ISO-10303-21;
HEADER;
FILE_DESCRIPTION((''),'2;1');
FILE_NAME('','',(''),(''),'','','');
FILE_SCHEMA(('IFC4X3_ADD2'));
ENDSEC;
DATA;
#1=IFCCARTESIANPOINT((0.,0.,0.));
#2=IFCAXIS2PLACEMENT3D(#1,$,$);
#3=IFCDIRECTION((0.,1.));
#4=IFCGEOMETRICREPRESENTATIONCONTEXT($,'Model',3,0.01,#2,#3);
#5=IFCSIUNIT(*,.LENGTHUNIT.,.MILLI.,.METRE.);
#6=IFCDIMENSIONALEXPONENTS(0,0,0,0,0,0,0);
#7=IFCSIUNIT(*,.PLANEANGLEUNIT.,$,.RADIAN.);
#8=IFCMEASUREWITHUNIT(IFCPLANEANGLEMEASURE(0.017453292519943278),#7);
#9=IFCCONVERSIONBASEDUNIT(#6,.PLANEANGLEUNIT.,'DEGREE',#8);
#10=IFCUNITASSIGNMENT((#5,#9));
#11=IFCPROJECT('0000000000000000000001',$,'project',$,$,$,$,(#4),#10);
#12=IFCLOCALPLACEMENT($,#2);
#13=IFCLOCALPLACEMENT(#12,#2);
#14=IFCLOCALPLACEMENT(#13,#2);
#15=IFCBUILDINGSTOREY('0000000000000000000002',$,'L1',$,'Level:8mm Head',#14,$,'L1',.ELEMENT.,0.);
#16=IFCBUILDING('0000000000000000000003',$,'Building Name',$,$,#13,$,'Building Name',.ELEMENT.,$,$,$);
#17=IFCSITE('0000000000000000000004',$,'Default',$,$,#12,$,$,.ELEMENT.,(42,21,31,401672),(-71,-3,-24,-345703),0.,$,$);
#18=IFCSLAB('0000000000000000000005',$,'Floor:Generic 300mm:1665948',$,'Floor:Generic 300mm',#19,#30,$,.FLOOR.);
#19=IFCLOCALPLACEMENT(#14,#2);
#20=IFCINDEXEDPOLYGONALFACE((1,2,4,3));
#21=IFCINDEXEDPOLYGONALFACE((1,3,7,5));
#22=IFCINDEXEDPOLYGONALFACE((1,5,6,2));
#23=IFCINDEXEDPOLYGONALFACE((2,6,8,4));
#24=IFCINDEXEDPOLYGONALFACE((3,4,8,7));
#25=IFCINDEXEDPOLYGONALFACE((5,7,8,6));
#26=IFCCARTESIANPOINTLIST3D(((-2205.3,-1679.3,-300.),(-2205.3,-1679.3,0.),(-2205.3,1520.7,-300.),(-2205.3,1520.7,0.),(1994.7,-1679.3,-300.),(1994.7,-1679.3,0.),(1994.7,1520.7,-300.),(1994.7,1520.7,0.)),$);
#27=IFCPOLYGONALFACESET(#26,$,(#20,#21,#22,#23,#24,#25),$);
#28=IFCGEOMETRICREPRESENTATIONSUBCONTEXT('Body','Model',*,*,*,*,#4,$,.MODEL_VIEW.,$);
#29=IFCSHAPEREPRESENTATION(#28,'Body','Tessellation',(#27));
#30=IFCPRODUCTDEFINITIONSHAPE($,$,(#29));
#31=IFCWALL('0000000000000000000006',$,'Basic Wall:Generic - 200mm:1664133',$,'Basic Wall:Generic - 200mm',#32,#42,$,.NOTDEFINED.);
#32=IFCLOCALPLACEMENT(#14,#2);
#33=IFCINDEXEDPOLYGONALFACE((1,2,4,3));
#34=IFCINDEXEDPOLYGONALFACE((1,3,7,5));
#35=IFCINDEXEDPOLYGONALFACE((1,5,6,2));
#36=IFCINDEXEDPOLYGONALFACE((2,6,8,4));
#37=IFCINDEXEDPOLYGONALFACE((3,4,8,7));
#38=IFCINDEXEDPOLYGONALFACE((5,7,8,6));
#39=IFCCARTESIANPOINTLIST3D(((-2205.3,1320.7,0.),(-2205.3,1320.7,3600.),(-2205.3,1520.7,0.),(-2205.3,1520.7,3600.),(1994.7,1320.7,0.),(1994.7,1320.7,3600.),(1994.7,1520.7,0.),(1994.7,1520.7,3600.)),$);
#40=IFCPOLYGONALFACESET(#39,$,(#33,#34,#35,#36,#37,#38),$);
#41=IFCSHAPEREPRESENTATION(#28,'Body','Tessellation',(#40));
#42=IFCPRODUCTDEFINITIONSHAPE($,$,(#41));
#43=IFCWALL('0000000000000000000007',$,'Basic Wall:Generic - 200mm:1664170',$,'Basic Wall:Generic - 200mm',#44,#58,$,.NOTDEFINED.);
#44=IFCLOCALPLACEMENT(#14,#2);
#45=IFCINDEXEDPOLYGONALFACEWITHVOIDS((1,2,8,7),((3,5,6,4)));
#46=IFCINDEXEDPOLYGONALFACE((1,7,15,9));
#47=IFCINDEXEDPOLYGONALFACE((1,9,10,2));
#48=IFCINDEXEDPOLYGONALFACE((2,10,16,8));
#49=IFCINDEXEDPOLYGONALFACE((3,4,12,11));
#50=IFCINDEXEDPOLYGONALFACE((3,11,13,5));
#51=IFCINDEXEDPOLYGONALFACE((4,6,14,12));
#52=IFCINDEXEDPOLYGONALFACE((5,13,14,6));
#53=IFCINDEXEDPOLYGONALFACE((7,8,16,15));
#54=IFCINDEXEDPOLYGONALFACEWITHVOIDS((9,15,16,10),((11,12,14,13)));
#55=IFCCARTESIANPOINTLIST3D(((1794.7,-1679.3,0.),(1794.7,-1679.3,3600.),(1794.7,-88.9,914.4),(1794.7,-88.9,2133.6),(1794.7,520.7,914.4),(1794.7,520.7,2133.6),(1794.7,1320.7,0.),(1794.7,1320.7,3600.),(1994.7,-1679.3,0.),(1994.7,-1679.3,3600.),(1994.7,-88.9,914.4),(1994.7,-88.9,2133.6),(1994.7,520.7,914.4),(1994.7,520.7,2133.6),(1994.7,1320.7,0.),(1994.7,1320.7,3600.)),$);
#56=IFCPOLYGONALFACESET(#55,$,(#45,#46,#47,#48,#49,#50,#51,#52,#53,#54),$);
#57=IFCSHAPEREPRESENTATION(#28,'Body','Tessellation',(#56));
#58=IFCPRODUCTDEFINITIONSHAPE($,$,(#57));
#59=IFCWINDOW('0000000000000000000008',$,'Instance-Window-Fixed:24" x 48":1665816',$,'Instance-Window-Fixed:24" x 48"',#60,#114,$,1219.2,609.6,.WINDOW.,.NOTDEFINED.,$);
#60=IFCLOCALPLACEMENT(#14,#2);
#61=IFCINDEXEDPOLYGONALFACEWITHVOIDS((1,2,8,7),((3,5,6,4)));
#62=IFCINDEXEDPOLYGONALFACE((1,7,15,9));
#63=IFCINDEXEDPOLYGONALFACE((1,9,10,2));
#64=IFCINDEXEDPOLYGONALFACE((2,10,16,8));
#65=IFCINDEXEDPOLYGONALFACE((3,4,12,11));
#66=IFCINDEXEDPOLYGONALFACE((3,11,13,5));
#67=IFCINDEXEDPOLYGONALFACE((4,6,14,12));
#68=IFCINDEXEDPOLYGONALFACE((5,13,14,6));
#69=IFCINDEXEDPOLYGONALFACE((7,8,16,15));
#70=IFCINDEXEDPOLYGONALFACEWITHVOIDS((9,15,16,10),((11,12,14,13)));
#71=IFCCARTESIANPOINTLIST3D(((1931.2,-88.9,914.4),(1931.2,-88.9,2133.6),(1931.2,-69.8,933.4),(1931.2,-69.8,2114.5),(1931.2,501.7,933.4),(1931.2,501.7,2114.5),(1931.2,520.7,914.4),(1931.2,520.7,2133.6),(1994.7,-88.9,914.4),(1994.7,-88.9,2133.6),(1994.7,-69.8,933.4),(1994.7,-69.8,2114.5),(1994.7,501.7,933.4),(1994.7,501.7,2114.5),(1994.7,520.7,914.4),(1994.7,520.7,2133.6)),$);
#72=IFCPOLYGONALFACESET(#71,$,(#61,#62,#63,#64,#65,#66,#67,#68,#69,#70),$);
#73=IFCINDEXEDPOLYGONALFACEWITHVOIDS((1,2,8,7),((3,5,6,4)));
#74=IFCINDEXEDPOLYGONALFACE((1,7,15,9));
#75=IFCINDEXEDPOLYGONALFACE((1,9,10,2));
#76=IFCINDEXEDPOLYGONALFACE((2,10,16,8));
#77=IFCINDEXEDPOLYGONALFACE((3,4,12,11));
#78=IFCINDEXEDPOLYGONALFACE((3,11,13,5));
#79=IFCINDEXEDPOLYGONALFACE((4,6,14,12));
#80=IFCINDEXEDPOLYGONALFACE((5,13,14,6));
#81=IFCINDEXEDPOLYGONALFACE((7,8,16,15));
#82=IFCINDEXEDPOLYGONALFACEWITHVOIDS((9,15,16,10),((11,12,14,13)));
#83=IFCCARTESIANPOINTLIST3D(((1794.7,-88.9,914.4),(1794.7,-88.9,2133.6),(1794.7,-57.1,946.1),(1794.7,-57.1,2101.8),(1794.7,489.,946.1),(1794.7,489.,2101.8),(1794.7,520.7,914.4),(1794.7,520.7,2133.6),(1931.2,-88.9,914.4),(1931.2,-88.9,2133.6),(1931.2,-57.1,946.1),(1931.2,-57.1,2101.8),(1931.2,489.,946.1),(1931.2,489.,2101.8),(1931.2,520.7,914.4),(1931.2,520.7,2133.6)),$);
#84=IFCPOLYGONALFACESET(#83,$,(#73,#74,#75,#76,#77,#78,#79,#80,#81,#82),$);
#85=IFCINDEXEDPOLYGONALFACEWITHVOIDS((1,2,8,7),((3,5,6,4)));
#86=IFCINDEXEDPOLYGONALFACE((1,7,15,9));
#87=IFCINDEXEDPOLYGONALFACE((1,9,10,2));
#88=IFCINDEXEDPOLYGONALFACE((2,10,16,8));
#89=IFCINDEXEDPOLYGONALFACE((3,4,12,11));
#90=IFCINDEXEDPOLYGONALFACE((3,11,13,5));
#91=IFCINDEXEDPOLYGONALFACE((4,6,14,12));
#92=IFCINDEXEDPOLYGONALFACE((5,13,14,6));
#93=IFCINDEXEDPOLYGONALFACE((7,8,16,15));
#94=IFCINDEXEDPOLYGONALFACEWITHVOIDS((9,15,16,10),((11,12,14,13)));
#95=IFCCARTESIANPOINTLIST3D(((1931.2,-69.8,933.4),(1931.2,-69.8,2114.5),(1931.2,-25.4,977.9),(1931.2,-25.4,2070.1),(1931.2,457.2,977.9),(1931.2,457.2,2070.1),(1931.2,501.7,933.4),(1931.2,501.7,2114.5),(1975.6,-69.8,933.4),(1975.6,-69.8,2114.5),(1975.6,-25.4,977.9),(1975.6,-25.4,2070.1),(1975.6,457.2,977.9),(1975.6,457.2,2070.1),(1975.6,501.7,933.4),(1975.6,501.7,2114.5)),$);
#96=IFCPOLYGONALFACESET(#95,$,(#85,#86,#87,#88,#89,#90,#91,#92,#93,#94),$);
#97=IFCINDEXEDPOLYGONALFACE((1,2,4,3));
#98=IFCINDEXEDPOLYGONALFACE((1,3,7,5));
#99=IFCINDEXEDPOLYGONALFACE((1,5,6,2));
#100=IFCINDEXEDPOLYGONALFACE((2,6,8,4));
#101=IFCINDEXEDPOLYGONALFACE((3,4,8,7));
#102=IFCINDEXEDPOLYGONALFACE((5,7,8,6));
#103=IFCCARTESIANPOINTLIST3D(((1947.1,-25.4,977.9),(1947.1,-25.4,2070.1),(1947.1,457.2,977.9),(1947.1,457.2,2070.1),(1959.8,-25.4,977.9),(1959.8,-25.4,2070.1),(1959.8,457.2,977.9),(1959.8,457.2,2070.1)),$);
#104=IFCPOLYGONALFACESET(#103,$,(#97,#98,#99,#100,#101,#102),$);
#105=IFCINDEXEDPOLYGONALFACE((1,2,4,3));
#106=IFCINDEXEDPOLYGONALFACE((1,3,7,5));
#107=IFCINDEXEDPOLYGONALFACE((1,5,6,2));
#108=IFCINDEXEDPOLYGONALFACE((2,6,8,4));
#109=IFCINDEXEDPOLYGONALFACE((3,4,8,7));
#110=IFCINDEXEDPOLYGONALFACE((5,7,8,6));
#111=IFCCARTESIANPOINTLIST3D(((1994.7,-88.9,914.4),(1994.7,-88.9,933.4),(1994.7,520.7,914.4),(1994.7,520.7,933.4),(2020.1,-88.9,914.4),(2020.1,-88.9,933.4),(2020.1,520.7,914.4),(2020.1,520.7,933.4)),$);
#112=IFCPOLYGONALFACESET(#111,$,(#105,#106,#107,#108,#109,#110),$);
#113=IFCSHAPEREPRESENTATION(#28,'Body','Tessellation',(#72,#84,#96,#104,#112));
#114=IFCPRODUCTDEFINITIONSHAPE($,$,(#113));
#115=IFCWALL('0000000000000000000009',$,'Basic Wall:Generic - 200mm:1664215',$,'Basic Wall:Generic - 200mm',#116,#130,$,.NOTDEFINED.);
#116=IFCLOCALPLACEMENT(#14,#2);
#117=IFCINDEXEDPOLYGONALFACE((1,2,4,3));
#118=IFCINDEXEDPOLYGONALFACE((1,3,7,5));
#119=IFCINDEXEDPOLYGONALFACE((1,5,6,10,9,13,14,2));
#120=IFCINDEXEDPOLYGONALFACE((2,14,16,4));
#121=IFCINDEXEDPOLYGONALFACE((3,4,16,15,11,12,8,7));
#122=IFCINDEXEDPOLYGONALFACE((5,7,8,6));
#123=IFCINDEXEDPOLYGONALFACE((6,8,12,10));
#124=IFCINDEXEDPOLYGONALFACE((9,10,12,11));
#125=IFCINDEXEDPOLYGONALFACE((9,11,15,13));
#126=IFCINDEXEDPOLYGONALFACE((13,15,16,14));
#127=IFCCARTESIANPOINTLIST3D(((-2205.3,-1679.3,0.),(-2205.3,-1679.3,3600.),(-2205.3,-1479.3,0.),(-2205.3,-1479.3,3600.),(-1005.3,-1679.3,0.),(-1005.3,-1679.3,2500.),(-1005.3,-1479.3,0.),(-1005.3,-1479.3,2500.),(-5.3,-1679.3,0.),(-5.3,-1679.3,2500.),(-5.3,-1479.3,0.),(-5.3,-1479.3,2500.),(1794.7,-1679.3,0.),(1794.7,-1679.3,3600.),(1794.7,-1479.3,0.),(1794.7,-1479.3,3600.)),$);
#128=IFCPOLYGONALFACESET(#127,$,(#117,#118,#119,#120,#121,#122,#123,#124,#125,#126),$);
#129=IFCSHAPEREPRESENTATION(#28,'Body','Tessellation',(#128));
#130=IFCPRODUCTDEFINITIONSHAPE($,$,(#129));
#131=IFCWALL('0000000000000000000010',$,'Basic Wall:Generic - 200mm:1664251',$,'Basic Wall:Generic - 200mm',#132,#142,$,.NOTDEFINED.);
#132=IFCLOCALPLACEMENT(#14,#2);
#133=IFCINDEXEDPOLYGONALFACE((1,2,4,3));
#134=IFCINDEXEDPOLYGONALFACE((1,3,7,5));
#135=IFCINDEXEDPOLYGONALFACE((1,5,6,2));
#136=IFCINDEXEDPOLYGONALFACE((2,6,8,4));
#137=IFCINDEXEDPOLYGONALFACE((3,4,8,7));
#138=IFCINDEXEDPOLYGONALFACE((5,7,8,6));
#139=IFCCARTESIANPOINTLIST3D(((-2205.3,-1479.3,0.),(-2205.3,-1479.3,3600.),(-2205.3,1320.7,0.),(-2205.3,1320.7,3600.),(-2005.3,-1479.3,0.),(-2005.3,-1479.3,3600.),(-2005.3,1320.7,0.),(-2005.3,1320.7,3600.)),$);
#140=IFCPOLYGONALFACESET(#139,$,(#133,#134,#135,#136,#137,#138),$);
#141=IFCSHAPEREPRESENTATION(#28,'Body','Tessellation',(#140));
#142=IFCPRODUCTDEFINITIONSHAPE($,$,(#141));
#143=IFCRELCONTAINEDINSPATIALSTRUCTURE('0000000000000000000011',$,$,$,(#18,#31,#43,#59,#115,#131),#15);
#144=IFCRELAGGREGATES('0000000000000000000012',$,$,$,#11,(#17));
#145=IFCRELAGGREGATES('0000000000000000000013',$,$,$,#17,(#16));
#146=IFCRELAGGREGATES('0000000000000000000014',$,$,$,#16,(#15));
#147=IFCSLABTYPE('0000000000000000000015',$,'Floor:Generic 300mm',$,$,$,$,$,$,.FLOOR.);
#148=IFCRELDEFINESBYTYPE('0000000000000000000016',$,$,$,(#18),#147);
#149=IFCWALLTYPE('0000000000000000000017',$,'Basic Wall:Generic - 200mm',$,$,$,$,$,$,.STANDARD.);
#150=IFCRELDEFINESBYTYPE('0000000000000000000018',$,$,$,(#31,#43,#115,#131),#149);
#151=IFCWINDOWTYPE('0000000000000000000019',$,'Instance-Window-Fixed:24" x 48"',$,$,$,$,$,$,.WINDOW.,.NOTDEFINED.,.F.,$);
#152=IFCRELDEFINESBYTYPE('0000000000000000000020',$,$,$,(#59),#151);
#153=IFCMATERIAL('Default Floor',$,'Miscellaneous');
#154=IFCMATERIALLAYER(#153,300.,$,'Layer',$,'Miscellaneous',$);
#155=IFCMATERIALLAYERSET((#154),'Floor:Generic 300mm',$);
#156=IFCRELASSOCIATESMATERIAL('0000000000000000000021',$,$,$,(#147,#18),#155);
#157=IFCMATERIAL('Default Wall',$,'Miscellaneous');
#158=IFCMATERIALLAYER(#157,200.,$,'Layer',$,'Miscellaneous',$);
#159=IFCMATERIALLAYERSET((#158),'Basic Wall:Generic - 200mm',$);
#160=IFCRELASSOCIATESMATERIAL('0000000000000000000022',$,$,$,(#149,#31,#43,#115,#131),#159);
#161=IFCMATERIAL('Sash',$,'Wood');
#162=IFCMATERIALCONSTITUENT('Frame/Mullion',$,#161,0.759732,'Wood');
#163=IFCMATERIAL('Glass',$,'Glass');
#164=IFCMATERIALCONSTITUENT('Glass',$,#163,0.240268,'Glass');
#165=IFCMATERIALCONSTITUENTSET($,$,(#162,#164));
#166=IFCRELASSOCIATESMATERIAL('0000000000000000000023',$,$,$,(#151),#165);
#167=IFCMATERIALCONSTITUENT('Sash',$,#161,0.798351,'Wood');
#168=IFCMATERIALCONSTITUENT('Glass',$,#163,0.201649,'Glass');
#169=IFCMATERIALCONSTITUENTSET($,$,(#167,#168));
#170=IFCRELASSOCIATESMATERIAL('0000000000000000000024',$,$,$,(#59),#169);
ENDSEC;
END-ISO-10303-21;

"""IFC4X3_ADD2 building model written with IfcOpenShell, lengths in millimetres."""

from ifc_helpers import new_model, entity, si_unit, converted_unit, direction, frame, frame_2d, origin, origin_2d_with_axis, place, context, subcontext, project, spatial, polyline, rectangle, outline, extrude, source, transform, mapped, material, layer, layer_set, layer_usage, constituent, constituent_set, type_object, type_shapes, element, fill, save


model = new_model("IFC4X3_ADD2")

# Units and contexts
model_context = context("Model", 3, precision=0.01, world=origin(), true_north=direction((0.0, 1.0)))
body_context = subcontext(model_context, "Body", "Model", "MODEL_VIEW")
ifc_project = project(units=[si_unit("LENGTHUNIT", "METRE", prefix="MILLI"), converted_unit("PLANEANGLEUNIT", "DEGREE", entity("IfcPlaneAngleMeasure", 0.017453292519943278), si_unit("PLANEANGLEUNIT", "RADIAN"), dimensions=[0, 0, 0, 0, 0, 0, 0])], contexts=[model_context])

# Site, building, storey
site_placement = place(None, origin())
site = spatial("IfcSite", under=ifc_project, at=site_placement, Name="Default", CompositionType="ELEMENT", RefLatitude=(42, 21, 31, 401672), RefLongitude=(-71, -3, -24, -345703), RefElevation=0.0)
building_placement = place(site_placement, origin())
building = spatial("IfcBuilding", under=site, at=building_placement, Name="Building Name", LongName="Building Name", CompositionType="ELEMENT")
storey_placement = place(building_placement, origin())
storey = spatial("IfcBuildingStorey", under=building, at=storey_placement, Name="L1", ObjectType="Level:8mm Head", LongName="L1", CompositionType="ELEMENT", Elevation=0.0)

# Slab
ifc_material_1 = material(Name="Default Floor", Category="Miscellaneous")
ifc_layer_1 = layer(ifc_material_1, 300.0, Name="Layer", Category="Miscellaneous")
ifc_layer_set_1 = layer_set([ifc_layer_1], Name="Floor:Generic 300mm")
ifc_layer_usage = layer_usage(ifc_layer_set_1, "AXIS3", "POSITIVE", 0.0)
slab_type = type_object("IfcSlabType", Name="Floor:Generic 300mm", PredefinedType="FLOOR", material=ifc_layer_set_1)
slab_placement = place(storey_placement, origin())
element("IfcSlab", 1, at=slab_placement, inside=storey, type_object=slab_type, material=ifc_layer_usage, Name="Floor:Generic 300mm:1665948", ObjectType="Floor:Generic 300mm", PredefinedType="FLOOR", context=body_context, shape_type="SweptSolid", body=[
    extrude(rectangle(XDim=3200.0, YDim=4200.0, at=origin_2d_with_axis()), frame((-105.3, -79.3, 0.0), z_axis=(0.0, 0.0, -1.0), x_axis=(0.0, 1.0, 0.0)), (0.0, 0.0, 1.0), 300.0),
])

# Wall
ifc_material_2 = material(Name="Default Wall", Category="Miscellaneous")
ifc_layer_2 = layer(ifc_material_2, 200.0, Name="Layer", Category="Miscellaneous")
ifc_layer_set_2 = layer_set([ifc_layer_2], Name="Basic Wall:Generic - 200mm")
wall_type = type_object("IfcWallType", Name="Basic Wall:Generic - 200mm", PredefinedType="STANDARD", material=ifc_layer_set_2)
wall_1_placement = place(storey_placement, frame((-2205.3, 1420.7, 0.0)))
element("IfcWall", 2, at=wall_1_placement, inside=storey, type_object=wall_type, material=ifc_layer_set_2, Name="Basic Wall:Generic - 200mm:1664133", ObjectType="Basic Wall:Generic - 200mm", PredefinedType="NOTDEFINED", context=body_context, shape_type="SweptSolid", body=[
    extrude(rectangle(XDim=4200.0, YDim=200.0, at=frame_2d((2100.0, 0.0), x_axis=(-1.0, 0.0))), origin(), (0.0, 0.0, 1.0), 3600.0),
])

# Wall, opening, window
wall_2_placement = place(storey_placement, frame((1894.7, 1320.7, 0.0), z_axis=(0.0, 0.0, 1.0), x_axis=(0.0, -1.0, 0.0)))
wall_2 = element("IfcWall", 3, at=wall_2_placement, inside=storey, type_object=wall_type, material=ifc_layer_set_2, Name="Basic Wall:Generic - 200mm:1664170", ObjectType="Basic Wall:Generic - 200mm", PredefinedType="NOTDEFINED", context=body_context, shape_type="SweptSolid", body=[
    extrude(rectangle(XDim=3000.0, YDim=200.0, at=frame_2d((1500.0, 0.0), x_axis=(-1.0, 0.0))), origin(), (0.0, 0.0, 1.0), 3600.0),
])
opening_1_placement = place(wall_2_placement, frame((800.0, -100.0, 914.4)))
opening_1 = element("IfcOpeningElement", 4, at=opening_1_placement, cuts=wall_2, PredefinedType="OPENING", context=body_context, shape_type="SweptSolid", body=[
    extrude(rectangle(XDim=1219.2, YDim=609.6, at=frame_2d((609.6, 304.8), x_axis=(-1.0, 0.0))), frame((0.0, 0.0, 0.0), z_axis=(0.0, 1.0, 0.0), x_axis=(0.0, 0.0, 1.0)), (0.0, 0.0, 1.0), 200.0),
])
ifc_material_3 = material(Name="Sash", Category="Wood")
ifc_constituent_1 = constituent(ifc_material_3, Name="Sash", Category="Wood", fraction=0.798351)
ifc_material_4 = material(Name="Glass", Category="Glass")
ifc_constituent_2 = constituent(ifc_material_4, Name="Glass", Category="Glass", fraction=0.201649)
ifc_constituent_set_1 = constituent_set(constituents=[ifc_constituent_1, ifc_constituent_2])
ifc_constituent_3 = constituent(ifc_material_3, Name="Frame/Mullion", Category="Wood", fraction=0.759732)
ifc_constituent_4 = constituent(ifc_material_4, Name="Glass", Category="Glass", fraction=0.240268)
ifc_constituent_set_2 = constituent_set(constituents=[ifc_constituent_3, ifc_constituent_4])
window_type = type_object("IfcWindowType", Name="Instance-Window-Fixed:24\" x 48\"", ParameterTakesPrecedence=False, PartitioningType="NOTDEFINED", PredefinedType="WINDOW", material=ifc_constituent_set_2)
shared_shape = source(origin(), body_context, "Body", "SweptSolid", [
    extrude(outline(polyline([(-609.6, -304.8), (609.6, -304.8), (609.6, 304.8), (-609.6, 304.8), (-609.6, -304.8)]), holes=[polyline([(-590.5, -285.7), (-590.5, 285.8), (590.6, 285.8), (590.6, -285.7), (-590.5, -285.7)])]), frame((304.8, 136.5, 609.6), z_axis=(0.0, 1.0, 0.0), x_axis=(0.0, 0.0, -1.0)), (0.0, 0.0, 1.0), 63.5),
    extrude(outline(polyline([(-304.8, -609.6), (304.8, -609.6), (304.8, 609.6), (-304.8, 609.6), (-304.8, -609.6)]), holes=[polyline([(-273.1, -577.8), (-273.1, 577.9), (273.0, 577.9), (273.0, -577.8), (-273.1, -577.8)])]), frame((304.8, 0.0, 609.6), z_axis=(0.0, 1.0, 0.0), x_axis=(1.0, 0.0, 0.0)), (0.0, 0.0, 1.0), 136.5),
    extrude(outline(polyline([(-285.7, -590.6), (285.7, -590.6), (285.7, 590.6), (-285.7, 590.6), (-285.7, -590.6)]), holes=[polyline([(-241.3, -546.1), (-241.3, 546.1), (241.3, 546.1), (241.3, -546.1), (-241.3, -546.1)])]), frame((304.8, 136.5, 609.6), z_axis=(0.0, 1.0, 0.0), x_axis=(1.0, 0.0, 0.0)), (0.0, 0.0, 1.0), 44.4),
    extrude(rectangle(XDim=12.7, YDim=482.6, at=frame_2d((0.0, 0.0), x_axis=(1.0, 0.0))), frame((304.8, 158.7, 63.5), z_axis=(0.0, 0.0, 1.0), x_axis=(0.0, 1.0, 0.0)), (0.0, 0.0, 1.0), 1092.2),
    extrude(rectangle(XDim=25.4, YDim=609.6, at=frame_2d((0.0, 0.0), x_axis=(1.0, 0.0))), frame((304.8, 212.7, 0.0), z_axis=(0.0, 0.0, 1.0), x_axis=(0.0, -1.0, 0.0)), (0.0, 0.0, 1.0), 19.0),
])
type_shapes(window_type, [shared_shape])
window_placement = place(opening_1_placement, origin())
window = element("IfcWindow", 5, at=window_placement, inside=storey, type_object=window_type, material=ifc_constituent_set_1, Name="Instance-Window-Fixed:24\" x 48\":1665816", ObjectType="Instance-Window-Fixed:24\" x 48\"", OverallHeight=1219.2, OverallWidth=609.6, PartitioningType="NOTDEFINED", PredefinedType="WINDOW", context=body_context, shape_type="MappedRepresentation", body=[
    mapped(shared_shape, transform((0.0, 0.0, 0.0), scale=1.0)),
])
fill(opening_1, window)

# Wall, opening
wall_3_placement = place(storey_placement, frame((1794.7, -1579.3, 0.0), z_axis=(0.0, 0.0, 1.0), x_axis=(-1.0, 0.0, 0.0)))
wall_3 = element("IfcWall", 6, at=wall_3_placement, inside=storey, type_object=wall_type, material=ifc_layer_set_2, Name="Basic Wall:Generic - 200mm:1664215", ObjectType="Basic Wall:Generic - 200mm", PredefinedType="NOTDEFINED", context=body_context, shape_type="SweptSolid", body=[
    extrude(rectangle(XDim=4000.0, YDim=200.0, at=frame_2d((2000.0, 0.0), x_axis=(1.0, 0.0))), origin(), (0.0, 0.0, 1.0), 3600.0),
])
opening_2_placement = place(wall_3_placement, frame((1800.0, -100.0, 0.0)))
element("IfcOpeningElement", 7, at=opening_2_placement, cuts=wall_3, PredefinedType="OPENING", context=body_context, shape_type="SweptSolid", body=[
    extrude(rectangle(XDim=2500.0, YDim=1000.0, at=frame_2d((1250.0, 500.0), x_axis=(1.0, 0.0))), frame((0.0, 0.0, 0.0), z_axis=(0.0, 1.0, 0.0), x_axis=(0.0, 0.0, 1.0)), (0.0, 0.0, 1.0), 200.0),
])

# Wall
wall_4_placement = place(storey_placement, frame((-2105.3, -1479.3, 0.0), z_axis=(0.0, 0.0, 1.0), x_axis=(0.0, 1.0, 0.0)))
element("IfcWall", 8, at=wall_4_placement, inside=storey, type_object=wall_type, material=ifc_layer_set_2, Name="Basic Wall:Generic - 200mm:1664251", ObjectType="Basic Wall:Generic - 200mm", PredefinedType="NOTDEFINED", context=body_context, shape_type="SweptSolid", body=[
    extrude(rectangle(XDim=2800.0, YDim=200.0, at=frame_2d((1400.0, 0.0), x_axis=(-1.0, 0.0))), origin(), (0.0, 0.0, 1.0), 3600.0),
])

save(model, "model.ifc")
